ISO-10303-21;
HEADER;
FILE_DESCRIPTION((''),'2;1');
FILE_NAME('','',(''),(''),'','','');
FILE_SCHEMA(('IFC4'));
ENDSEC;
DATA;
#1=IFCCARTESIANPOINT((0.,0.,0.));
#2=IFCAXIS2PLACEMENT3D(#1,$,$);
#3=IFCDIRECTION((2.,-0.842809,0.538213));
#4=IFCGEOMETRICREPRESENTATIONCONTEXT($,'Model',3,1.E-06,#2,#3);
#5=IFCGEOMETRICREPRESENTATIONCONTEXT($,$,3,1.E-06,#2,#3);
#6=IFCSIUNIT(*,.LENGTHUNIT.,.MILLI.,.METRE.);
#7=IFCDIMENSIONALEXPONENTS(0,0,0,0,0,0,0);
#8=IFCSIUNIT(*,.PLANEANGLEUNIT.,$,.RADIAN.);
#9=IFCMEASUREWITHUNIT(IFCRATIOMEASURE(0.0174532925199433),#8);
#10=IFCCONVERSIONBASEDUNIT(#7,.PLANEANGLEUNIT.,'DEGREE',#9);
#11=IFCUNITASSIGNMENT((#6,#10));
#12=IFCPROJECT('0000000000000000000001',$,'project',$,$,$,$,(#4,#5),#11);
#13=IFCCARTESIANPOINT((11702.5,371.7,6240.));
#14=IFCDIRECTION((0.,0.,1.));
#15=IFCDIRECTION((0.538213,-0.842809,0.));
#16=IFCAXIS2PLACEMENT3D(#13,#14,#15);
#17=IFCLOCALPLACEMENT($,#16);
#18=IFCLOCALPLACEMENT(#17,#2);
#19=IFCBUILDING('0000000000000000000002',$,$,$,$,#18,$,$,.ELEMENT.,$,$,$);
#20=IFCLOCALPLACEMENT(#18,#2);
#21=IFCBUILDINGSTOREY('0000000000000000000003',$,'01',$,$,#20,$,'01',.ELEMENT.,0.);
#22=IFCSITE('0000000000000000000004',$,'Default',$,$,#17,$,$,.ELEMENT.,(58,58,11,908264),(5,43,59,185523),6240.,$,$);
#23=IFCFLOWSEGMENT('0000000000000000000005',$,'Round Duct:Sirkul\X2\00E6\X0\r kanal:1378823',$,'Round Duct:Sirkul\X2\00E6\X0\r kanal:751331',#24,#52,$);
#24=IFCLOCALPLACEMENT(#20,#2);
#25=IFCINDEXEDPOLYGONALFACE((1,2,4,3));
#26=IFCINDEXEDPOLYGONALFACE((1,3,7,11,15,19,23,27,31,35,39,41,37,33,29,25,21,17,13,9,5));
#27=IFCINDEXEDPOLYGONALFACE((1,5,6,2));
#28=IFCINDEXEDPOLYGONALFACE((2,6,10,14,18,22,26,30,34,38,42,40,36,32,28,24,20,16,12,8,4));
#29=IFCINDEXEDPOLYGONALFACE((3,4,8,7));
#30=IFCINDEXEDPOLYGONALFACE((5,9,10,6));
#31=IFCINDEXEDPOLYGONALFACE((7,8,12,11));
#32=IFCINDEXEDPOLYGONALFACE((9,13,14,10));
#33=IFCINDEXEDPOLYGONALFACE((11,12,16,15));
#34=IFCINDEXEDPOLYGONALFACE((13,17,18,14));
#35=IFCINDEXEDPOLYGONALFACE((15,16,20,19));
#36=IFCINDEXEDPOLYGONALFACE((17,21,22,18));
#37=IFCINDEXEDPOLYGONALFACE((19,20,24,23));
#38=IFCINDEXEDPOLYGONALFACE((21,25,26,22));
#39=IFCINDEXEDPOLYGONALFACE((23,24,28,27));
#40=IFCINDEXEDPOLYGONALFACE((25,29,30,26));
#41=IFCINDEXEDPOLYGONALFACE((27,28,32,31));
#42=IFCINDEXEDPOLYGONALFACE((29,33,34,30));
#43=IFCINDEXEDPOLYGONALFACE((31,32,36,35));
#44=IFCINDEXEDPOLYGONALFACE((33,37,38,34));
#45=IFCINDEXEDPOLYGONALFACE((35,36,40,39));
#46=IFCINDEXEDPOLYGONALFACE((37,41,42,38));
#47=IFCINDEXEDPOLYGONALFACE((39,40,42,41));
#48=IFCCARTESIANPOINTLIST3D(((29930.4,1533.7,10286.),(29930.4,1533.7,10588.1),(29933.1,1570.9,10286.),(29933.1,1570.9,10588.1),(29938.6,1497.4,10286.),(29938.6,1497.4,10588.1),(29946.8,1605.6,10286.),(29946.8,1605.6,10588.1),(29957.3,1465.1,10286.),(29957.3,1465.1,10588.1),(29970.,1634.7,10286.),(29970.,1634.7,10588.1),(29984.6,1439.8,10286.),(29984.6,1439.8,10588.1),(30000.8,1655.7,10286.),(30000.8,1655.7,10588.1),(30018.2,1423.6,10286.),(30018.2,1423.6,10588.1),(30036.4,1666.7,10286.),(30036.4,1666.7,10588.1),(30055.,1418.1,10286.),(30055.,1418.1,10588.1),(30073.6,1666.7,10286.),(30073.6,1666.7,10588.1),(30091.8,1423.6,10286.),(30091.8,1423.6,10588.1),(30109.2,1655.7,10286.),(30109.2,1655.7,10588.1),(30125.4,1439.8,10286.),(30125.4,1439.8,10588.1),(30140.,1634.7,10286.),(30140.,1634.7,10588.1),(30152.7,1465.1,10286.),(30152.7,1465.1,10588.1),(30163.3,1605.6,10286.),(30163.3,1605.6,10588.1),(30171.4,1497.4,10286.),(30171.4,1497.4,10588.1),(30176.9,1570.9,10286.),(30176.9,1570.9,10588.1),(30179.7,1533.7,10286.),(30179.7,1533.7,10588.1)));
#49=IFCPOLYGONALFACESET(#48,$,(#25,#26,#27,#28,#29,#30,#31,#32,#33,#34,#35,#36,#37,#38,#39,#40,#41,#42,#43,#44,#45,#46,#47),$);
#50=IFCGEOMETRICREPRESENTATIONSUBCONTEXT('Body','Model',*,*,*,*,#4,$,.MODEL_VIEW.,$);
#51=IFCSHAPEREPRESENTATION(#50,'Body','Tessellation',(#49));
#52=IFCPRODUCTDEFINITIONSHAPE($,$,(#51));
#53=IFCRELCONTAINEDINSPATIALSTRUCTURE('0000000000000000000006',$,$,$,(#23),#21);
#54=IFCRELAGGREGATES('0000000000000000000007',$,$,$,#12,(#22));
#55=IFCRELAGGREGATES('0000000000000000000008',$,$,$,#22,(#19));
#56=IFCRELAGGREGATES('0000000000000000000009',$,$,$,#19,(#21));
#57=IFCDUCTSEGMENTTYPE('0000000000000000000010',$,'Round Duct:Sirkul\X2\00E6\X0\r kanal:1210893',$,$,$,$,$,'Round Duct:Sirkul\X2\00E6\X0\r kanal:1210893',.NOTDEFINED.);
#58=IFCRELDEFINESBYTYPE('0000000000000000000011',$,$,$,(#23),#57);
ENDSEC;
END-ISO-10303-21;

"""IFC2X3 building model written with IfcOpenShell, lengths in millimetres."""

from ifc_helpers import new_model, entity, si_unit, converted_unit, direction, frame, frame_2d, origin, place, context, subcontext, project, spatial, circle, extrude, type_object, element, save


model = new_model("IFC2X3")

# Units and contexts
model_context = context("Model", 3, precision=1e-06, world=origin(), true_north=direction((2.0, -0.842809, 0.538213)))
context_of_model = context(None, 3, precision=1e-06, world=origin(), true_north=direction((2.0, -0.842809, 0.538213)))
body_context = subcontext(model_context, "Body", "Model", "MODEL_VIEW")
ifc_project = project(units=[si_unit("LENGTHUNIT", "METRE", prefix="MILLI"), converted_unit("PLANEANGLEUNIT", "DEGREE", entity("IfcRatioMeasure", 0.0174532925199433), si_unit("PLANEANGLEUNIT", "RADIAN"), dimensions=[0, 0, 0, 0, 0, 0, 0])], contexts=[model_context, context_of_model])

# Site, building, storey
site_placement = place(None, frame((11702.5, 371.7, 6240.0), z_axis=(0.0, 0.0, 1.0), x_axis=(0.538213, -0.842809, 0.0)))
site = spatial("IfcSite", under=ifc_project, at=site_placement, Name="Default", CompositionType="ELEMENT", RefLatitude=(58, 58, 11, 908264), RefLongitude=(5, 43, 59, 185523), RefElevation=6240.0)
building_placement = place(site_placement, origin())
building = spatial("IfcBuilding", under=site, at=building_placement, CompositionType="ELEMENT")
storey_placement = place(building_placement, origin())
storey = spatial("IfcBuildingStorey", under=building, at=storey_placement, Name="01", LongName="01", CompositionType="ELEMENT", Elevation=0.0)

# Flow segment
duct_segment_type = type_object("IfcDuctSegmentType", Name="Round Duct:Sirkulær kanal:1210893", ElementType="Round Duct:Sirkulær kanal:1210893", PredefinedType="NOTDEFINED")
flow_segment_1_placement = place(storey_placement, origin())
element("IfcFlowSegment", 1, at=flow_segment_1_placement, inside=storey, type_object=duct_segment_type, Name="Round Duct:Sirkulær kanal:1378823", ObjectType="Round Duct:Sirkulær kanal:751331", context=body_context, shape_type="SweptSolid", body=[
    extrude(circle(Radius=125.0, at=frame_2d((0.0, 0.0), x_axis=(1.0, 0.0))), frame((30055.0, 1543.1, 10286.0), z_axis=(0.0, 0.0, 1.0), x_axis=(0.0, -1.0, 0.0)), (0.0, 0.0, 1.0), 302.1),
])

save(model, "model.ifc")
